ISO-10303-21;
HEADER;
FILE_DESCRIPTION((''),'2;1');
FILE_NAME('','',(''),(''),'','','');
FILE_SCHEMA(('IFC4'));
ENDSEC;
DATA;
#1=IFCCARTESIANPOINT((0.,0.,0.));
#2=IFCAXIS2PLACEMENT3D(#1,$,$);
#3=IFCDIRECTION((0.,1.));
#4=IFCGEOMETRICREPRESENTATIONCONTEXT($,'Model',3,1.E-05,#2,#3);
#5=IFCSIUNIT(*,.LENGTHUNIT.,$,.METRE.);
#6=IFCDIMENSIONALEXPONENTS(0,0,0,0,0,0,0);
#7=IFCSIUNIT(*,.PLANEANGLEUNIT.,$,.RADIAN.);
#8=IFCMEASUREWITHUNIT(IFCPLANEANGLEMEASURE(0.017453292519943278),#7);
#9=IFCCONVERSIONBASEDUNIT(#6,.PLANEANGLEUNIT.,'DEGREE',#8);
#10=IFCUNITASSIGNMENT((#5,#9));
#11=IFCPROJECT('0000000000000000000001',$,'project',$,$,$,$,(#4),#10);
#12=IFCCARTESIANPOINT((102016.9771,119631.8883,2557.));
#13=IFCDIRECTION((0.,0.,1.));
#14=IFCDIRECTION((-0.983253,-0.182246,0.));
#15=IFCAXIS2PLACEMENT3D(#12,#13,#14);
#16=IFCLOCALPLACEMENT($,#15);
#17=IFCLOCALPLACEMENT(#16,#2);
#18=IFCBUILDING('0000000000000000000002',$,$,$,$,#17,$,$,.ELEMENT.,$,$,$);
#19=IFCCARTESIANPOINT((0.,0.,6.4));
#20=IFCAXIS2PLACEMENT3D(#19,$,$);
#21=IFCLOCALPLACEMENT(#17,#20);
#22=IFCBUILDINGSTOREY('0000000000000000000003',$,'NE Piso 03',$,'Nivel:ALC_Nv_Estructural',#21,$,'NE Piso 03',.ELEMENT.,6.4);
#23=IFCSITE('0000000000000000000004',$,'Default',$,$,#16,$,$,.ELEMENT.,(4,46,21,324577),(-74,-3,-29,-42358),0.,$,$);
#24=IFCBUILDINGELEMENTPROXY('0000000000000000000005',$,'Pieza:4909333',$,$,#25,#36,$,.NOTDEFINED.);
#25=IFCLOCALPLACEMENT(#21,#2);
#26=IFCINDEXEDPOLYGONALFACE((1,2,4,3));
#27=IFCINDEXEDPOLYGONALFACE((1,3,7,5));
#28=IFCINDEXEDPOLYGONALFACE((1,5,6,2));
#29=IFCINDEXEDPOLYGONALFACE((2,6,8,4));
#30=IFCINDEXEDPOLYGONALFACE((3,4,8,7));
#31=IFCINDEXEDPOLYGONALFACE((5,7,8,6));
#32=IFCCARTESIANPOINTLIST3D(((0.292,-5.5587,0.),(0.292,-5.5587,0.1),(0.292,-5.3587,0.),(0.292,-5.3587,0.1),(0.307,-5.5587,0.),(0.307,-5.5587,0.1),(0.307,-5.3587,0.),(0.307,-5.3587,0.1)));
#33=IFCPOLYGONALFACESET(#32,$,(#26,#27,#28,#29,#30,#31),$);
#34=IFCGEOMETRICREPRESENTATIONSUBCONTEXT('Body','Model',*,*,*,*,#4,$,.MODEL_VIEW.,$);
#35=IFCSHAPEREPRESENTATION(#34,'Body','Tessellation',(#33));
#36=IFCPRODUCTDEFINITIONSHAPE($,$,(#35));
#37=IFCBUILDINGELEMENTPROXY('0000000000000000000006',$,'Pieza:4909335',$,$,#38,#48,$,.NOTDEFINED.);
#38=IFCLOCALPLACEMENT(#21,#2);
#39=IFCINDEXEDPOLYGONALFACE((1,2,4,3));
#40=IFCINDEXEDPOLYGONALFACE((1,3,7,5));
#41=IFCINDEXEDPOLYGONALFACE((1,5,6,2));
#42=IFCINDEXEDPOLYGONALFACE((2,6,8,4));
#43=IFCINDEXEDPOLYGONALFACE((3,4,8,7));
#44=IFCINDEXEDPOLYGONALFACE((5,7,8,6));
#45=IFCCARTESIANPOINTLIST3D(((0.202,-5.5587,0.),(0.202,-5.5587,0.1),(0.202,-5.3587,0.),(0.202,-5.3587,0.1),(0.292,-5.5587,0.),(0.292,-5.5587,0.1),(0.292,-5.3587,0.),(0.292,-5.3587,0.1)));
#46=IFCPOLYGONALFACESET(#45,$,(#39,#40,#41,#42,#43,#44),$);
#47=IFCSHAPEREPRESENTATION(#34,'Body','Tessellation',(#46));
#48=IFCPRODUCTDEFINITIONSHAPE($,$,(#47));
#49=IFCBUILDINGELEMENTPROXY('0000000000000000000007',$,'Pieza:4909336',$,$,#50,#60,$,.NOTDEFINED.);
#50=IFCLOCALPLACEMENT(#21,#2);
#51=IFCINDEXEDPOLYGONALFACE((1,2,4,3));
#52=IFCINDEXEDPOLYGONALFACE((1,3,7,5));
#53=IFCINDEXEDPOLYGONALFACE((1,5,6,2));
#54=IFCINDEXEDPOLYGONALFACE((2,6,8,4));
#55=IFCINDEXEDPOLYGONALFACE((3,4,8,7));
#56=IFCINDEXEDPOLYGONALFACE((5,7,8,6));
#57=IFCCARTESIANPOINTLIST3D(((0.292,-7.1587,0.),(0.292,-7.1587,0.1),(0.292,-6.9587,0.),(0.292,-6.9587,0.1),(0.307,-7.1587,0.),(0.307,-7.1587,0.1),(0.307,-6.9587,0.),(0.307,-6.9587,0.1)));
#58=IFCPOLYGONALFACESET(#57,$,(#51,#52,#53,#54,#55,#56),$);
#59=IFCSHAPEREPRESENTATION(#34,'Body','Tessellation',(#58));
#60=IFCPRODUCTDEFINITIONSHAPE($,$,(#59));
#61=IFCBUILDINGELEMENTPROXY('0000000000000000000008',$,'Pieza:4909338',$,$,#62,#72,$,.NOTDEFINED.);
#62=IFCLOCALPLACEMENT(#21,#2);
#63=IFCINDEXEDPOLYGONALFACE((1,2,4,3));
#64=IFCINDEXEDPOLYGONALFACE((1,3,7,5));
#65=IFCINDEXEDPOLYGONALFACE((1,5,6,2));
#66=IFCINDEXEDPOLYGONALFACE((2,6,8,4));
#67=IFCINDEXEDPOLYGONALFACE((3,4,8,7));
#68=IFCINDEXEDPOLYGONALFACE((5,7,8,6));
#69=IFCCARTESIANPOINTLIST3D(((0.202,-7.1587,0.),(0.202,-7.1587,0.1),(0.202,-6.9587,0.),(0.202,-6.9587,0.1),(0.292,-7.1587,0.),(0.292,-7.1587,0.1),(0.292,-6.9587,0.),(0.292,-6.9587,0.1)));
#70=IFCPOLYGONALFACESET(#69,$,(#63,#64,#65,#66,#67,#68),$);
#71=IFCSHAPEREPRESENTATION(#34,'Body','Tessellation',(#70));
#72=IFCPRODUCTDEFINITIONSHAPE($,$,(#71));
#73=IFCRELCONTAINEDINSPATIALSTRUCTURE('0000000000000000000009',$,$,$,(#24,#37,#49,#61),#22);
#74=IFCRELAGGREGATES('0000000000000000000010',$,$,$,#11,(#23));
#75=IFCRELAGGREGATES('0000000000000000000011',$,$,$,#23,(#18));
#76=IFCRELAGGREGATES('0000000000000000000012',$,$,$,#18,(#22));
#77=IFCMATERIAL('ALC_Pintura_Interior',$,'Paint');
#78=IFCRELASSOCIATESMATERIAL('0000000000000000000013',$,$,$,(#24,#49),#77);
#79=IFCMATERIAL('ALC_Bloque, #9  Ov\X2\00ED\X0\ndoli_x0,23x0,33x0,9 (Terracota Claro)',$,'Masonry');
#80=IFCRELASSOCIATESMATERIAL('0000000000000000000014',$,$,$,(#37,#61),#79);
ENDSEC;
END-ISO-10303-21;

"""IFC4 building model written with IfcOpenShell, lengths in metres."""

from ifc_helpers import new_model, entity, si_unit, converted_unit, direction, frame, frame_2d, origin, place, context, subcontext, project, spatial, rectangle, extrude, material, element, save


model = new_model("IFC4")

# Units and contexts
model_context = context("Model", 3, precision=1e-05, world=origin(), true_north=direction((0.0, 1.0)))
body_context = subcontext(model_context, "Body", "Model", "MODEL_VIEW")
ifc_project = project(units=[si_unit("LENGTHUNIT", "METRE"), converted_unit("PLANEANGLEUNIT", "DEGREE", entity("IfcPlaneAngleMeasure", 0.017453292519943278), si_unit("PLANEANGLEUNIT", "RADIAN"), dimensions=[0, 0, 0, 0, 0, 0, 0])], contexts=[model_context])

# Site, building, storey
site_placement = place(None, frame((102016.9771, 119631.8883, 2557.0), z_axis=(0.0, 0.0, 1.0), x_axis=(-0.983253, -0.182246, 0.0)))
site = spatial("IfcSite", under=ifc_project, at=site_placement, Name="Default", CompositionType="ELEMENT", RefLatitude=(4, 46, 21, 324577), RefLongitude=(-74, -3, -29, -42358), RefElevation=0.0)
building_placement = place(site_placement, origin())
building = spatial("IfcBuilding", under=site, at=building_placement, CompositionType="ELEMENT")
storey_placement = place(building_placement, frame((0.0, 0.0, 6.4)))
storey = spatial("IfcBuildingStorey", under=building, at=storey_placement, Name="NE Piso 03", ObjectType="Nivel:ALC_Nv_Estructural", LongName="NE Piso 03", CompositionType="ELEMENT", Elevation=6.4)

# Shared definitions
ifc_material_1 = material(Name="ALC_Pintura_Interior", Category="Paint")
ifc_material_2 = material(Name="ALC_Bloque, #9  Ovíndoli_x0,23x0,33x0,9 (Terracota Claro)", Category="Masonry")

# Building element proxies
proxy_1_placement = place(storey_placement, origin())
element("IfcBuildingElementProxy", 1, at=proxy_1_placement, inside=storey, material=ifc_material_1, Name="Pieza:4909333", PredefinedType="NOTDEFINED", context=body_context, shape_type="SweptSolid", body=[
    extrude(rectangle(XDim=0.1, YDim=0.2, at=frame_2d((0.0, 0.0), x_axis=(1.0, 0.0))), frame((0.292, -5.4587, 0.05), z_axis=(1.0, 0.0, 0.0), x_axis=(0.0, 0.0, -1.0)), (0.0, 0.0, 1.0), 0.015),
])
proxy_2_placement = place(storey_placement, origin())
element("IfcBuildingElementProxy", 2, at=proxy_2_placement, inside=storey, material=ifc_material_2, Name="Pieza:4909335", PredefinedType="NOTDEFINED", context=body_context, shape_type="SweptSolid", body=[
    extrude(rectangle(XDim=0.1, YDim=0.2, at=frame_2d((0.0, 0.0), x_axis=(1.0, 0.0))), frame((0.202, -5.4587, 0.05), z_axis=(1.0, 0.0, 0.0), x_axis=(0.0, 0.0, -1.0)), (0.0, 0.0, 1.0), 0.09),
])
proxy_3_placement = place(storey_placement, origin())
element("IfcBuildingElementProxy", 3, at=proxy_3_placement, inside=storey, material=ifc_material_1, Name="Pieza:4909336", PredefinedType="NOTDEFINED", context=body_context, shape_type="SweptSolid", body=[
    extrude(rectangle(XDim=0.1, YDim=0.2, at=frame_2d((0.0, 0.0), x_axis=(1.0, 0.0))), frame((0.292, -7.0587, 0.05), z_axis=(1.0, 0.0, 0.0), x_axis=(0.0, 0.0, -1.0)), (0.0, 0.0, 1.0), 0.015),
])
proxy_4_placement = place(storey_placement, origin())
element("IfcBuildingElementProxy", 4, at=proxy_4_placement, inside=storey, material=ifc_material_2, Name="Pieza:4909338", PredefinedType="NOTDEFINED", context=body_context, shape_type="SweptSolid", body=[
    extrude(rectangle(XDim=0.1, YDim=0.2, at=frame_2d((0.0, 0.0), x_axis=(1.0, 0.0))), frame((0.202, -7.0587, 0.05), z_axis=(1.0, 0.0, 0.0), x_axis=(0.0, 0.0, -1.0)), (0.0, 0.0, 1.0), 0.09),
])

save(model, "model.ifc")
